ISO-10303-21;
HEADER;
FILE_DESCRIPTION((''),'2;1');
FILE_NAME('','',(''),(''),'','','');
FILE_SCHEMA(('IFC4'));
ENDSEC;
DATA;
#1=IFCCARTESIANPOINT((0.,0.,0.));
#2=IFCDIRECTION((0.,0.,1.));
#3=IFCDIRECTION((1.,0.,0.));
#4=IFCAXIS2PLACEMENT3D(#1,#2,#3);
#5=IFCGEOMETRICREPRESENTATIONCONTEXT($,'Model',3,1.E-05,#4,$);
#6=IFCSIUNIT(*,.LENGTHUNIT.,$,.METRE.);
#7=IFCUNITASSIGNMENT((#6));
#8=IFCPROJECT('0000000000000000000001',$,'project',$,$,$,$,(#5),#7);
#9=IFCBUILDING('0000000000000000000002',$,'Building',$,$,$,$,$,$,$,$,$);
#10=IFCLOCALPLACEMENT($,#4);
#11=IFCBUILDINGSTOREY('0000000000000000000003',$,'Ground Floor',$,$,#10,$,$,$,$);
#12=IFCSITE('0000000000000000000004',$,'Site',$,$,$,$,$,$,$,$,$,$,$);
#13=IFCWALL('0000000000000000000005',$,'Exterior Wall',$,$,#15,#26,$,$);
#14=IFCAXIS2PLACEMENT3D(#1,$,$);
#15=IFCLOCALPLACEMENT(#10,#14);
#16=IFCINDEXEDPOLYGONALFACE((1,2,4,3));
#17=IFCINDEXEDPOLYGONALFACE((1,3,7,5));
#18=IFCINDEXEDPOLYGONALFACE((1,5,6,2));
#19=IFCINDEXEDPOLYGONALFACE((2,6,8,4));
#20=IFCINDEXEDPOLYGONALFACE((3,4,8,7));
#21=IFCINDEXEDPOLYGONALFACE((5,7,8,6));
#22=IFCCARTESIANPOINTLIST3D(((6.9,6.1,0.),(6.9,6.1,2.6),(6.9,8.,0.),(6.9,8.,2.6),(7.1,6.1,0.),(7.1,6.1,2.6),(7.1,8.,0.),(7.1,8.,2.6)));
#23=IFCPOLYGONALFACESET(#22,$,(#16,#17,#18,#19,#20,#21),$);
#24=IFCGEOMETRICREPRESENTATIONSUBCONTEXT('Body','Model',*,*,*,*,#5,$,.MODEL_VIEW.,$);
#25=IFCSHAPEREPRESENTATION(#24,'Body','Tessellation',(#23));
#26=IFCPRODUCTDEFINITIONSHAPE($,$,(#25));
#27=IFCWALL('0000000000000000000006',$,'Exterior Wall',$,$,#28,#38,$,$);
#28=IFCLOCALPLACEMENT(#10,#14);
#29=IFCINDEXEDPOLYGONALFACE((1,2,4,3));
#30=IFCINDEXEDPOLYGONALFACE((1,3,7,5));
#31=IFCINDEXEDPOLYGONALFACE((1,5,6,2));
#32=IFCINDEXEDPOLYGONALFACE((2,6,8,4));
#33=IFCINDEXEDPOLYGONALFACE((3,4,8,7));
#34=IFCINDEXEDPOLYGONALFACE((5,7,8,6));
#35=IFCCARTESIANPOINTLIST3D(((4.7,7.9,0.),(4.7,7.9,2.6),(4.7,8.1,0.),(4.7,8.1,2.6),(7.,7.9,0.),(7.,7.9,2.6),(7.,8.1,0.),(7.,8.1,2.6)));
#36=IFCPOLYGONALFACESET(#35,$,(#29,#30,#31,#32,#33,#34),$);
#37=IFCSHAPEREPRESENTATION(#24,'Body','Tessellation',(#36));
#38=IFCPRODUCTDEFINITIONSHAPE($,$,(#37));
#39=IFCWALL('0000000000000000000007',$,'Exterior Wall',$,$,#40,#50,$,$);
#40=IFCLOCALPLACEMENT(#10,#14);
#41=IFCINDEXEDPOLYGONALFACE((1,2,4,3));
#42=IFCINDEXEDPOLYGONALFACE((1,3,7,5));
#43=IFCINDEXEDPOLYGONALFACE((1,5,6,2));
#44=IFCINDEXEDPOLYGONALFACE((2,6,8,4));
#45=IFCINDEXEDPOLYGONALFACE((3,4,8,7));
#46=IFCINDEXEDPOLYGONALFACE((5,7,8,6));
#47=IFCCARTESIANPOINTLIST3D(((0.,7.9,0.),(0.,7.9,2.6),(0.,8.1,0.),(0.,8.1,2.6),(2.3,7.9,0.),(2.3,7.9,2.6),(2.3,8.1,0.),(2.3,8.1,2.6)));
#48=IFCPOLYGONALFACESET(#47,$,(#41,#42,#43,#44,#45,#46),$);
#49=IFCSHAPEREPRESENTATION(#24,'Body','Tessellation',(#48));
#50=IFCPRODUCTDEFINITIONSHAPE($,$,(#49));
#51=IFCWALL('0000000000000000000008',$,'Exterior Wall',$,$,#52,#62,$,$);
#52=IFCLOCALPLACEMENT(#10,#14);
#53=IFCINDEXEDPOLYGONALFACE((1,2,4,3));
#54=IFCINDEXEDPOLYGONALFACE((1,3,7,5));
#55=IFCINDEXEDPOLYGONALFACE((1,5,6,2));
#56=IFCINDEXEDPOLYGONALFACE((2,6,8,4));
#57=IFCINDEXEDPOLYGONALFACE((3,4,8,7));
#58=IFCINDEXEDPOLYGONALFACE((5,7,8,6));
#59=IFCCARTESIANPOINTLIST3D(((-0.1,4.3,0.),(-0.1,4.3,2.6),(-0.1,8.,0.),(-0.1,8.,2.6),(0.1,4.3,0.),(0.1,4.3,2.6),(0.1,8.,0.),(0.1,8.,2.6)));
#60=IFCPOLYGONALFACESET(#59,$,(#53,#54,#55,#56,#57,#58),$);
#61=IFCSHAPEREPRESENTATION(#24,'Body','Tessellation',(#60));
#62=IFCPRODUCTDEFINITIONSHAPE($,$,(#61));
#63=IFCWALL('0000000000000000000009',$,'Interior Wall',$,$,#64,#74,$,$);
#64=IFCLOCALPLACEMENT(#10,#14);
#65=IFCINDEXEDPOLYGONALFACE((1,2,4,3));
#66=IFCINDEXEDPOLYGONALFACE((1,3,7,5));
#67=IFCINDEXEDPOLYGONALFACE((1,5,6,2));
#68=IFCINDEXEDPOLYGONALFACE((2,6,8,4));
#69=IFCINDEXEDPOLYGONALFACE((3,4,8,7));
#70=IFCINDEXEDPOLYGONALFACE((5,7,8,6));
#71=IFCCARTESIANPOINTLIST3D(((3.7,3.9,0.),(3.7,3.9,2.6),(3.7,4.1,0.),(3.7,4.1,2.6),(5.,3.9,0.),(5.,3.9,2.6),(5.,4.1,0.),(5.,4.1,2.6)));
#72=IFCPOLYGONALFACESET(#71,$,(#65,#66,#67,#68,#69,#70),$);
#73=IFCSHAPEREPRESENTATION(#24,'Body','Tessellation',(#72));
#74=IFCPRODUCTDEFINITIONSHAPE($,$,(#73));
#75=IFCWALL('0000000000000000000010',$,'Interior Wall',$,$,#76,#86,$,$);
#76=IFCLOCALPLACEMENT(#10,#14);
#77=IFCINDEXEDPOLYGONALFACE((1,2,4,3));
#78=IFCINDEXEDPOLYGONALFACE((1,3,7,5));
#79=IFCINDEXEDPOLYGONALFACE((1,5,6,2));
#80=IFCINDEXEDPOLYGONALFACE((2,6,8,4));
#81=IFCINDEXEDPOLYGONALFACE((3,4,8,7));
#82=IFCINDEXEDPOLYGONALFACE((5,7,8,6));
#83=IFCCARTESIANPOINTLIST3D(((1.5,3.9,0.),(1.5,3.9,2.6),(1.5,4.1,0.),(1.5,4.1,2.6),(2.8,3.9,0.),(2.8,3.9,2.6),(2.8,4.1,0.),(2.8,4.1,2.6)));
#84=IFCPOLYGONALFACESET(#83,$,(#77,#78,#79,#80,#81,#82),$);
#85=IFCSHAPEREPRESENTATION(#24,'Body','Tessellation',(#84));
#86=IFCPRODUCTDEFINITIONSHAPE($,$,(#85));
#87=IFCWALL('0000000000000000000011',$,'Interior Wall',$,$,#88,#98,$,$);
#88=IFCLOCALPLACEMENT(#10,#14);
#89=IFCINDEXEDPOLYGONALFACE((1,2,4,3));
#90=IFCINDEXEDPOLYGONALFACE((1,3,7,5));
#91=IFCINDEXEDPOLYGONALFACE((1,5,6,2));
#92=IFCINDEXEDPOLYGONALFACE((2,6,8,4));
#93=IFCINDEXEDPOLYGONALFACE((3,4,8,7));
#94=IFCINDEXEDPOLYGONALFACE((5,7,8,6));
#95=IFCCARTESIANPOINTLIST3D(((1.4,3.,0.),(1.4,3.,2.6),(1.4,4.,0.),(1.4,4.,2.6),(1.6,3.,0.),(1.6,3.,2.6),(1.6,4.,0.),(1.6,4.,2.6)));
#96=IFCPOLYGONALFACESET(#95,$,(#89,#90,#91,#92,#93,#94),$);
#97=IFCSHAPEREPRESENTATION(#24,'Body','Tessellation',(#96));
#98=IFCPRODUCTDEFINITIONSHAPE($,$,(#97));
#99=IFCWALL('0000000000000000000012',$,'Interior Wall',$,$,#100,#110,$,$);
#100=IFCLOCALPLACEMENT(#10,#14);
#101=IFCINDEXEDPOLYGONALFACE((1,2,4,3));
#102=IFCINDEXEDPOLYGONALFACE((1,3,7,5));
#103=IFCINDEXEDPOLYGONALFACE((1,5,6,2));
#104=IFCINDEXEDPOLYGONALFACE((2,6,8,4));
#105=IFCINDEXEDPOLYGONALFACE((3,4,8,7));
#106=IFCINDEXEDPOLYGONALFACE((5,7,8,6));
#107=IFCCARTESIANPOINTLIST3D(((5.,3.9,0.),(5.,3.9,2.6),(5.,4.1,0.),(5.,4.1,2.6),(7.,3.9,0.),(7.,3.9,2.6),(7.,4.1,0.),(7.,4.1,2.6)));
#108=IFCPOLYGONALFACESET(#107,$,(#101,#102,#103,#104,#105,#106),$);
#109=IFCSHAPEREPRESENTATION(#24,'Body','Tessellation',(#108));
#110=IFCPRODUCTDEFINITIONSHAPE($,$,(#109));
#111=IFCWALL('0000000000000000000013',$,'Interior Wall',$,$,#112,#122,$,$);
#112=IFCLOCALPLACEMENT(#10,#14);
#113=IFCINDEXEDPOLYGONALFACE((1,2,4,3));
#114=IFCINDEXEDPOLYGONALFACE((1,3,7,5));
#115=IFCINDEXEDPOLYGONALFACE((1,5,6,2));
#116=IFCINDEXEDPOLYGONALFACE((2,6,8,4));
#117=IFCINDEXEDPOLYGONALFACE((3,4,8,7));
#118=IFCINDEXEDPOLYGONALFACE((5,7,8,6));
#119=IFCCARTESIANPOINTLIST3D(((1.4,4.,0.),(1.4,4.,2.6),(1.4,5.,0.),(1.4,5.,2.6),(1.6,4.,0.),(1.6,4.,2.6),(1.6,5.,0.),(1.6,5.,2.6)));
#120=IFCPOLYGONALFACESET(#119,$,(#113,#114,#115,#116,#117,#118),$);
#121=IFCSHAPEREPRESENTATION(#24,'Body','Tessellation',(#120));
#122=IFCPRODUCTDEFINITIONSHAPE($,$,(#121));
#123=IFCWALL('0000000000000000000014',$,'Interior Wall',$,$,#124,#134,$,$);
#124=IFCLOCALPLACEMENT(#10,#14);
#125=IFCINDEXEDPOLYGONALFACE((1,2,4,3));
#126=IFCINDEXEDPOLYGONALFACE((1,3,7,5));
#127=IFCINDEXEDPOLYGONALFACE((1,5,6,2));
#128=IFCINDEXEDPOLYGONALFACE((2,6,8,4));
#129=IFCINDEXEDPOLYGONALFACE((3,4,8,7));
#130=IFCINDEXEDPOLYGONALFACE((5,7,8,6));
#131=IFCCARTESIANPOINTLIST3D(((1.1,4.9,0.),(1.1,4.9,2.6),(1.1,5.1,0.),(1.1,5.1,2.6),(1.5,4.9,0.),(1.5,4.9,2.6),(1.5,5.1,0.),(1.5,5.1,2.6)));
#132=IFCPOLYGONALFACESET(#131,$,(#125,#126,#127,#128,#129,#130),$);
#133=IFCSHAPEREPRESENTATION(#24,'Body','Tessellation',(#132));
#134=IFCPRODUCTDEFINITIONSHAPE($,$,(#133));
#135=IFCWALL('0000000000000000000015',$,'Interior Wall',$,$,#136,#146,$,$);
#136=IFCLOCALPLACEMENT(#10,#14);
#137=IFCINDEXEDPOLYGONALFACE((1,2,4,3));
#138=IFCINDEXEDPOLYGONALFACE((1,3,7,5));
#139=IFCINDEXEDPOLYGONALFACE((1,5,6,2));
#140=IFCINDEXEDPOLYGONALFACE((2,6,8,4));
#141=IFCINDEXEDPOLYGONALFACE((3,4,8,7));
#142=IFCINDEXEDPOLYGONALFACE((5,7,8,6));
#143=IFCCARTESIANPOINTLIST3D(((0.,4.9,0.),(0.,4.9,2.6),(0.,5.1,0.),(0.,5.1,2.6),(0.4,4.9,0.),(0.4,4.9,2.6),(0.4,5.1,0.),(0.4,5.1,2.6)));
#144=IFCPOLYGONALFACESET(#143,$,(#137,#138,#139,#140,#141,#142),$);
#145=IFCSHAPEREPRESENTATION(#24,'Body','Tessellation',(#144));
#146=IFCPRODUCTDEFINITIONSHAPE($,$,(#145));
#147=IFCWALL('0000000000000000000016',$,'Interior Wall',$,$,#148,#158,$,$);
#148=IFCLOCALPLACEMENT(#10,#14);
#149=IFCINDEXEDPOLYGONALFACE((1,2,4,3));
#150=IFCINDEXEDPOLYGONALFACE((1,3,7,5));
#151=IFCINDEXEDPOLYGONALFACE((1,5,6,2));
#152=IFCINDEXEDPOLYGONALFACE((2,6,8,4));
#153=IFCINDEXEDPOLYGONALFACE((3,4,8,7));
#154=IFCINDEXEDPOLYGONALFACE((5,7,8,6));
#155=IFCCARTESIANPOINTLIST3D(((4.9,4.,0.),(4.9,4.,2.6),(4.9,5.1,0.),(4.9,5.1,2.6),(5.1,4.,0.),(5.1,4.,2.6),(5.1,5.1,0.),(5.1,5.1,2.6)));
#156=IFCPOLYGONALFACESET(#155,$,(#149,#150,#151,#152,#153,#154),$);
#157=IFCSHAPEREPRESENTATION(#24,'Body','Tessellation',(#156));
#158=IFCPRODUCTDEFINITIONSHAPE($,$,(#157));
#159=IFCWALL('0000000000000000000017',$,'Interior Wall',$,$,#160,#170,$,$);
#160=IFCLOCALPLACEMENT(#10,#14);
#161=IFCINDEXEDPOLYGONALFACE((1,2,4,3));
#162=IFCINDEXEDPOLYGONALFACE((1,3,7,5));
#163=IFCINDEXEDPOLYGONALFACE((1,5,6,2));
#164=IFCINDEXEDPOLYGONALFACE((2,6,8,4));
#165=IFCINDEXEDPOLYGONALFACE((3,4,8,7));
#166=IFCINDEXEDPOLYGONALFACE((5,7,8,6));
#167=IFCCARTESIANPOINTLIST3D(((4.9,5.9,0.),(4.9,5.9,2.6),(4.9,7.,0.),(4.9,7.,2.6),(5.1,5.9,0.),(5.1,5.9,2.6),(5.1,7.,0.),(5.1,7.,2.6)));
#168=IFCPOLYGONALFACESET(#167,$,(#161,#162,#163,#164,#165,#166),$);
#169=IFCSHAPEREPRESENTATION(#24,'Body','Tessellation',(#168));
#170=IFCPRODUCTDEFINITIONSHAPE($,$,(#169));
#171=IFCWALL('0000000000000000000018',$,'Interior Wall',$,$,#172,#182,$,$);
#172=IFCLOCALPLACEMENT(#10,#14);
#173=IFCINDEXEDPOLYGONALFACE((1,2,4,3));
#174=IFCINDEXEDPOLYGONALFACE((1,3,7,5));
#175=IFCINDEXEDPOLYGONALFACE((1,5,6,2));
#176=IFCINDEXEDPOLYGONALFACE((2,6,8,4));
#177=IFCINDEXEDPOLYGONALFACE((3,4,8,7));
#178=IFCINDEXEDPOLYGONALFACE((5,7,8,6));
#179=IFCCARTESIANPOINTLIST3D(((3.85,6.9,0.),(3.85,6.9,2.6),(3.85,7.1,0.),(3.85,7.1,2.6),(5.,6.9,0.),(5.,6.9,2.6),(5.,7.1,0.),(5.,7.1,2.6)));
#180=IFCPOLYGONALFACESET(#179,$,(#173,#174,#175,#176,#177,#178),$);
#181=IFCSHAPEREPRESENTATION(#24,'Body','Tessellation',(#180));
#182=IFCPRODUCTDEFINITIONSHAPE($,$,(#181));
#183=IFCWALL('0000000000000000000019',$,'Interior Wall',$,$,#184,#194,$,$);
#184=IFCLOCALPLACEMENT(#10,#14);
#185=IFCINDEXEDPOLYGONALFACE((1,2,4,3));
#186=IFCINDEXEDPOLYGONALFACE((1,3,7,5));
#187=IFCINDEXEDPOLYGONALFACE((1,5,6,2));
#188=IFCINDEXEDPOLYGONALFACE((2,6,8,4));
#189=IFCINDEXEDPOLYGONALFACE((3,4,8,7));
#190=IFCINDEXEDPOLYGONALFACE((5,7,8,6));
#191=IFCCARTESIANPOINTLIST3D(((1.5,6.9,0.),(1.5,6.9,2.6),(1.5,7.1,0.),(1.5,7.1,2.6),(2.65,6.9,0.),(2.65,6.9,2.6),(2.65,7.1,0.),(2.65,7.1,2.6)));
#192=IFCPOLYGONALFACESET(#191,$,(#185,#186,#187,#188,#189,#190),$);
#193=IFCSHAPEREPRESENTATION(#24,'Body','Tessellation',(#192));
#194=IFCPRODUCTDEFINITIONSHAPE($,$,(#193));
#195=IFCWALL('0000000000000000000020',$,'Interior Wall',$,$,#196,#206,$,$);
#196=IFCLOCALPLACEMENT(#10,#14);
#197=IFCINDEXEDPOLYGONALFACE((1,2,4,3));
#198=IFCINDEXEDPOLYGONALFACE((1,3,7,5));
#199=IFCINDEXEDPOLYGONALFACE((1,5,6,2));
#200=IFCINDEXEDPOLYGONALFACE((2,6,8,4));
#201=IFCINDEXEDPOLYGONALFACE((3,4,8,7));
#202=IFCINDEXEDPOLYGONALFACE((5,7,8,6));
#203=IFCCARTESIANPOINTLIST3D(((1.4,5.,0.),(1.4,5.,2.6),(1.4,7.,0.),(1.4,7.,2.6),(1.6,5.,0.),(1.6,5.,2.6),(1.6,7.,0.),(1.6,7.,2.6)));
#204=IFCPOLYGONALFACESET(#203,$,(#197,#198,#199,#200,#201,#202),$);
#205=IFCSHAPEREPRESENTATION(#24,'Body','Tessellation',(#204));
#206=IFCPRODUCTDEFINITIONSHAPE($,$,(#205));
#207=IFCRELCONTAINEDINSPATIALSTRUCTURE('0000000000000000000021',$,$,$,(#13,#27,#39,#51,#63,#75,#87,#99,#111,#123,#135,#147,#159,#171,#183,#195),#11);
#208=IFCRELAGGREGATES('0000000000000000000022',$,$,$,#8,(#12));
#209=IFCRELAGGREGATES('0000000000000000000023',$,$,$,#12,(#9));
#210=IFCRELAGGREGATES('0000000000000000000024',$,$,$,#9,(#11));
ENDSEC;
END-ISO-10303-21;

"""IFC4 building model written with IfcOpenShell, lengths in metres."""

from ifc_helpers import new_model, si_unit, frame, origin_with_axes, place, context, subcontext, project, spatial, indexed_curve, outline, extrude, element, save


model = new_model("IFC4")

# Units and contexts
model_context = context("Model", 3, precision=1e-05, world=origin_with_axes())
body_context = subcontext(model_context, "Body", "Model", "MODEL_VIEW")
ifc_project = project(units=[si_unit("LENGTHUNIT", "METRE")], contexts=[model_context])

# Site, building, storey
site = spatial("IfcSite", under=ifc_project, Name="Site")
building = spatial("IfcBuilding", under=site, Name="Building")
storey_placement = place(None, origin_with_axes())
storey = spatial("IfcBuildingStorey", under=building, at=storey_placement, Name="Ground Floor")

# Walls
wall_1_placement = place(storey_placement, frame((7.0, 6.1, 0.0), z_axis=(0.0, 0.0, 1.0), x_axis=(0.0, 1.0, 0.0)))
element("IfcWall", 1, at=wall_1_placement, inside=storey, Name="Exterior Wall", context=body_context, shape_type="SweptSolid", body=[
    extrude(outline(indexed_curve([(0.0, 0.0), (0.0, 0.2), (1.9, 0.2), (1.9, 0.0), (0.0, 0.0)], self_intersect=False)), frame((0.0, -0.1, 0.0), z_axis=(0.0, 0.0, 1.0), x_axis=(1.0, 0.0, 0.0)), (0.0, 0.0, 1.0), 2.6),
])
for number, where, z_axis, x_axis, name in (
    (2, (7.0, 8.0, 0.0), (0.0, 0.0, 1.0), (-1.0, 0.0, 0.0), "Exterior Wall"),
    (3, (2.3, 8.0, 0.0), (0.0, 0.0, 1.0), (-1.0, 0.0, 0.0), "Exterior Wall"),
):
    element("IfcWall", number, at=place(storey_placement, frame(where, z_axis=z_axis, x_axis=x_axis)), inside=storey, Name=name, context=body_context, shape_type="SweptSolid", body=[
        extrude(outline(indexed_curve([(0.0, 0.0), (0.0, 0.2), (2.3, 0.2), (2.3, 0.0), (0.0, 0.0)], self_intersect=False)), frame((0.0, -0.1, 0.0), z_axis=(0.0, 0.0, 1.0), x_axis=(1.0, 0.0, 0.0)), (0.0, 0.0, 1.0), 2.6),
    ])
wall_2_placement = place(storey_placement, frame((0.0, 8.0, 0.0), z_axis=(0.0, 0.0, 1.0), x_axis=(0.0, -1.0, 0.0)))
element("IfcWall", 4, at=wall_2_placement, inside=storey, Name="Exterior Wall", context=body_context, shape_type="SweptSolid", body=[
    extrude(outline(indexed_curve([(0.0, 0.0), (0.0, 0.2), (3.7, 0.2), (3.7, 0.0), (0.0, 0.0)], self_intersect=False)), frame((0.0, -0.1, 0.0), z_axis=(0.0, 0.0, 1.0), x_axis=(1.0, 0.0, 0.0)), (0.0, 0.0, 1.0), 2.6),
])
for number, where, z_axis, x_axis, name in (
    (5, (5.0, 4.0, 0.0), (0.0, 0.0, 1.0), (-1.0, 0.0, 0.0), "Interior Wall"),
    (6, (2.8, 4.0, 0.0), (0.0, 0.0, 1.0), (-1.0, 0.0, 0.0), "Interior Wall"),
):
    element("IfcWall", number, at=place(storey_placement, frame(where, z_axis=z_axis, x_axis=x_axis)), inside=storey, Name=name, context=body_context, shape_type="SweptSolid", body=[
        extrude(outline(indexed_curve([(0.0, 0.0), (0.0, 0.2), (1.3, 0.2), (1.3, 0.0), (0.0, 0.0)], self_intersect=False)), frame((0.0, -0.1, 0.0), z_axis=(0.0, 0.0, 1.0), x_axis=(1.0, 0.0, 0.0)), (0.0, 0.0, 1.0), 2.6),
    ])
wall_3_placement = place(storey_placement, frame((1.5, 4.0, 0.0), z_axis=(0.0, 0.0, 1.0), x_axis=(0.0, -1.0, 0.0)))
element("IfcWall", 7, at=wall_3_placement, inside=storey, Name="Interior Wall", context=body_context, shape_type="SweptSolid", body=[
    extrude(outline(indexed_curve([(0.0, 0.0), (0.0, 0.2), (1.0, 0.2), (1.0, 0.0), (0.0, 0.0)], self_intersect=False)), frame((0.0, -0.1, 0.0), z_axis=(0.0, 0.0, 1.0), x_axis=(1.0, 0.0, 0.0)), (0.0, 0.0, 1.0), 2.6),
])
wall_4_placement = place(storey_placement, frame((7.0, 4.0, 0.0), z_axis=(0.0, 0.0, 1.0), x_axis=(-1.0, 0.0, 0.0)))
element("IfcWall", 8, at=wall_4_placement, inside=storey, Name="Interior Wall", context=body_context, shape_type="SweptSolid", body=[
    extrude(outline(indexed_curve([(0.0, 0.0), (0.0, 0.2), (2.0, 0.2), (2.0, 0.0), (0.0, 0.0)], self_intersect=False)), frame((0.0, -0.1, 0.0), z_axis=(0.0, 0.0, 1.0), x_axis=(1.0, 0.0, 0.0)), (0.0, 0.0, 1.0), 2.6),
])
wall_5_placement = place(storey_placement, frame((1.5, 4.0, 0.0), z_axis=(0.0, 0.0, 1.0), x_axis=(0.0, 1.0, 0.0)))
element("IfcWall", 9, at=wall_5_placement, inside=storey, Name="Interior Wall", context=body_context, shape_type="SweptSolid", body=[
    extrude(outline(indexed_curve([(0.0, 0.0), (0.0, 0.2), (1.0, 0.2), (1.0, 0.0), (0.0, 0.0)], self_intersect=False)), frame((0.0, -0.1, 0.0), z_axis=(0.0, 0.0, 1.0), x_axis=(1.0, 0.0, 0.0)), (0.0, 0.0, 1.0), 2.6),
])
for number, where, z_axis, x_axis, name in (
    (10, (1.5, 5.0, 0.0), (0.0, 0.0, 1.0), (-1.0, 0.0, 0.0), "Interior Wall"),
    (11, (0.4, 5.0, 0.0), (0.0, 0.0, 1.0), (-1.0, 0.0, 0.0), "Interior Wall"),
):
    element("IfcWall", number, at=place(storey_placement, frame(where, z_axis=z_axis, x_axis=x_axis)), inside=storey, Name=name, context=body_context, shape_type="SweptSolid", body=[
        extrude(outline(indexed_curve([(0.0, 0.0), (0.0, 0.2), (0.4, 0.2), (0.4, 0.0), (0.0, 0.0)], self_intersect=False)), frame((0.0, -0.1, 0.0), z_axis=(0.0, 0.0, 1.0), x_axis=(1.0, 0.0, 0.0)), (0.0, 0.0, 1.0), 2.6),
    ])
for number, where, z_axis, x_axis, name in (
    (12, (5.0, 4.0, 0.0), (0.0, 0.0, 1.0), (0.0, 1.0, 0.0), "Interior Wall"),
    (13, (5.0, 5.9, 0.0), (0.0, 0.0, 1.0), (0.0, 1.0, 0.0), "Interior Wall"),
):
    element("IfcWall", number, at=place(storey_placement, frame(where, z_axis=z_axis, x_axis=x_axis)), inside=storey, Name=name, context=body_context, shape_type="SweptSolid", body=[
        extrude(outline(indexed_curve([(0.0, 0.0), (0.0, 0.2), (1.1, 0.2), (1.1, 0.0), (0.0, 0.0)], self_intersect=False)), frame((0.0, -0.1, 0.0), z_axis=(0.0, 0.0, 1.0), x_axis=(1.0, 0.0, 0.0)), (0.0, 0.0, 1.0), 2.6),
    ])
for number, where, z_axis, x_axis, name in (
    (14, (5.0, 7.0, 0.0), (0.0, 0.0, 1.0), (-1.0, 0.0, 0.0), "Interior Wall"),
    (15, (2.65, 7.0, 0.0), (0.0, 0.0, 1.0), (-1.0, 0.0, 0.0), "Interior Wall"),
):
    element("IfcWall", number, at=place(storey_placement, frame(where, z_axis=z_axis, x_axis=x_axis)), inside=storey, Name=name, context=body_context, shape_type="SweptSolid", body=[
        extrude(outline(indexed_curve([(0.0, 0.0), (0.0, 0.2), (1.15, 0.2), (1.15, 0.0), (0.0, 0.0)], self_intersect=False)), frame((0.0, -0.1, 0.0), z_axis=(0.0, 0.0, 1.0), x_axis=(1.0, 0.0, 0.0)), (0.0, 0.0, 1.0), 2.6),
    ])
wall_6_placement = place(storey_placement, frame((1.5, 7.0, 0.0), z_axis=(0.0, 0.0, 1.0), x_axis=(0.0, -1.0, 0.0)))
element("IfcWall", 16, at=wall_6_placement, inside=storey, Name="Interior Wall", context=body_context, shape_type="SweptSolid", body=[
    extrude(outline(indexed_curve([(0.0, 0.0), (0.0, 0.2), (2.0, 0.2), (2.0, 0.0), (0.0, 0.0)], self_intersect=False)), frame((0.0, -0.1, 0.0), z_axis=(0.0, 0.0, 1.0), x_axis=(1.0, 0.0, 0.0)), (0.0, 0.0, 1.0), 2.6),
])

save(model, "model.ifc")
